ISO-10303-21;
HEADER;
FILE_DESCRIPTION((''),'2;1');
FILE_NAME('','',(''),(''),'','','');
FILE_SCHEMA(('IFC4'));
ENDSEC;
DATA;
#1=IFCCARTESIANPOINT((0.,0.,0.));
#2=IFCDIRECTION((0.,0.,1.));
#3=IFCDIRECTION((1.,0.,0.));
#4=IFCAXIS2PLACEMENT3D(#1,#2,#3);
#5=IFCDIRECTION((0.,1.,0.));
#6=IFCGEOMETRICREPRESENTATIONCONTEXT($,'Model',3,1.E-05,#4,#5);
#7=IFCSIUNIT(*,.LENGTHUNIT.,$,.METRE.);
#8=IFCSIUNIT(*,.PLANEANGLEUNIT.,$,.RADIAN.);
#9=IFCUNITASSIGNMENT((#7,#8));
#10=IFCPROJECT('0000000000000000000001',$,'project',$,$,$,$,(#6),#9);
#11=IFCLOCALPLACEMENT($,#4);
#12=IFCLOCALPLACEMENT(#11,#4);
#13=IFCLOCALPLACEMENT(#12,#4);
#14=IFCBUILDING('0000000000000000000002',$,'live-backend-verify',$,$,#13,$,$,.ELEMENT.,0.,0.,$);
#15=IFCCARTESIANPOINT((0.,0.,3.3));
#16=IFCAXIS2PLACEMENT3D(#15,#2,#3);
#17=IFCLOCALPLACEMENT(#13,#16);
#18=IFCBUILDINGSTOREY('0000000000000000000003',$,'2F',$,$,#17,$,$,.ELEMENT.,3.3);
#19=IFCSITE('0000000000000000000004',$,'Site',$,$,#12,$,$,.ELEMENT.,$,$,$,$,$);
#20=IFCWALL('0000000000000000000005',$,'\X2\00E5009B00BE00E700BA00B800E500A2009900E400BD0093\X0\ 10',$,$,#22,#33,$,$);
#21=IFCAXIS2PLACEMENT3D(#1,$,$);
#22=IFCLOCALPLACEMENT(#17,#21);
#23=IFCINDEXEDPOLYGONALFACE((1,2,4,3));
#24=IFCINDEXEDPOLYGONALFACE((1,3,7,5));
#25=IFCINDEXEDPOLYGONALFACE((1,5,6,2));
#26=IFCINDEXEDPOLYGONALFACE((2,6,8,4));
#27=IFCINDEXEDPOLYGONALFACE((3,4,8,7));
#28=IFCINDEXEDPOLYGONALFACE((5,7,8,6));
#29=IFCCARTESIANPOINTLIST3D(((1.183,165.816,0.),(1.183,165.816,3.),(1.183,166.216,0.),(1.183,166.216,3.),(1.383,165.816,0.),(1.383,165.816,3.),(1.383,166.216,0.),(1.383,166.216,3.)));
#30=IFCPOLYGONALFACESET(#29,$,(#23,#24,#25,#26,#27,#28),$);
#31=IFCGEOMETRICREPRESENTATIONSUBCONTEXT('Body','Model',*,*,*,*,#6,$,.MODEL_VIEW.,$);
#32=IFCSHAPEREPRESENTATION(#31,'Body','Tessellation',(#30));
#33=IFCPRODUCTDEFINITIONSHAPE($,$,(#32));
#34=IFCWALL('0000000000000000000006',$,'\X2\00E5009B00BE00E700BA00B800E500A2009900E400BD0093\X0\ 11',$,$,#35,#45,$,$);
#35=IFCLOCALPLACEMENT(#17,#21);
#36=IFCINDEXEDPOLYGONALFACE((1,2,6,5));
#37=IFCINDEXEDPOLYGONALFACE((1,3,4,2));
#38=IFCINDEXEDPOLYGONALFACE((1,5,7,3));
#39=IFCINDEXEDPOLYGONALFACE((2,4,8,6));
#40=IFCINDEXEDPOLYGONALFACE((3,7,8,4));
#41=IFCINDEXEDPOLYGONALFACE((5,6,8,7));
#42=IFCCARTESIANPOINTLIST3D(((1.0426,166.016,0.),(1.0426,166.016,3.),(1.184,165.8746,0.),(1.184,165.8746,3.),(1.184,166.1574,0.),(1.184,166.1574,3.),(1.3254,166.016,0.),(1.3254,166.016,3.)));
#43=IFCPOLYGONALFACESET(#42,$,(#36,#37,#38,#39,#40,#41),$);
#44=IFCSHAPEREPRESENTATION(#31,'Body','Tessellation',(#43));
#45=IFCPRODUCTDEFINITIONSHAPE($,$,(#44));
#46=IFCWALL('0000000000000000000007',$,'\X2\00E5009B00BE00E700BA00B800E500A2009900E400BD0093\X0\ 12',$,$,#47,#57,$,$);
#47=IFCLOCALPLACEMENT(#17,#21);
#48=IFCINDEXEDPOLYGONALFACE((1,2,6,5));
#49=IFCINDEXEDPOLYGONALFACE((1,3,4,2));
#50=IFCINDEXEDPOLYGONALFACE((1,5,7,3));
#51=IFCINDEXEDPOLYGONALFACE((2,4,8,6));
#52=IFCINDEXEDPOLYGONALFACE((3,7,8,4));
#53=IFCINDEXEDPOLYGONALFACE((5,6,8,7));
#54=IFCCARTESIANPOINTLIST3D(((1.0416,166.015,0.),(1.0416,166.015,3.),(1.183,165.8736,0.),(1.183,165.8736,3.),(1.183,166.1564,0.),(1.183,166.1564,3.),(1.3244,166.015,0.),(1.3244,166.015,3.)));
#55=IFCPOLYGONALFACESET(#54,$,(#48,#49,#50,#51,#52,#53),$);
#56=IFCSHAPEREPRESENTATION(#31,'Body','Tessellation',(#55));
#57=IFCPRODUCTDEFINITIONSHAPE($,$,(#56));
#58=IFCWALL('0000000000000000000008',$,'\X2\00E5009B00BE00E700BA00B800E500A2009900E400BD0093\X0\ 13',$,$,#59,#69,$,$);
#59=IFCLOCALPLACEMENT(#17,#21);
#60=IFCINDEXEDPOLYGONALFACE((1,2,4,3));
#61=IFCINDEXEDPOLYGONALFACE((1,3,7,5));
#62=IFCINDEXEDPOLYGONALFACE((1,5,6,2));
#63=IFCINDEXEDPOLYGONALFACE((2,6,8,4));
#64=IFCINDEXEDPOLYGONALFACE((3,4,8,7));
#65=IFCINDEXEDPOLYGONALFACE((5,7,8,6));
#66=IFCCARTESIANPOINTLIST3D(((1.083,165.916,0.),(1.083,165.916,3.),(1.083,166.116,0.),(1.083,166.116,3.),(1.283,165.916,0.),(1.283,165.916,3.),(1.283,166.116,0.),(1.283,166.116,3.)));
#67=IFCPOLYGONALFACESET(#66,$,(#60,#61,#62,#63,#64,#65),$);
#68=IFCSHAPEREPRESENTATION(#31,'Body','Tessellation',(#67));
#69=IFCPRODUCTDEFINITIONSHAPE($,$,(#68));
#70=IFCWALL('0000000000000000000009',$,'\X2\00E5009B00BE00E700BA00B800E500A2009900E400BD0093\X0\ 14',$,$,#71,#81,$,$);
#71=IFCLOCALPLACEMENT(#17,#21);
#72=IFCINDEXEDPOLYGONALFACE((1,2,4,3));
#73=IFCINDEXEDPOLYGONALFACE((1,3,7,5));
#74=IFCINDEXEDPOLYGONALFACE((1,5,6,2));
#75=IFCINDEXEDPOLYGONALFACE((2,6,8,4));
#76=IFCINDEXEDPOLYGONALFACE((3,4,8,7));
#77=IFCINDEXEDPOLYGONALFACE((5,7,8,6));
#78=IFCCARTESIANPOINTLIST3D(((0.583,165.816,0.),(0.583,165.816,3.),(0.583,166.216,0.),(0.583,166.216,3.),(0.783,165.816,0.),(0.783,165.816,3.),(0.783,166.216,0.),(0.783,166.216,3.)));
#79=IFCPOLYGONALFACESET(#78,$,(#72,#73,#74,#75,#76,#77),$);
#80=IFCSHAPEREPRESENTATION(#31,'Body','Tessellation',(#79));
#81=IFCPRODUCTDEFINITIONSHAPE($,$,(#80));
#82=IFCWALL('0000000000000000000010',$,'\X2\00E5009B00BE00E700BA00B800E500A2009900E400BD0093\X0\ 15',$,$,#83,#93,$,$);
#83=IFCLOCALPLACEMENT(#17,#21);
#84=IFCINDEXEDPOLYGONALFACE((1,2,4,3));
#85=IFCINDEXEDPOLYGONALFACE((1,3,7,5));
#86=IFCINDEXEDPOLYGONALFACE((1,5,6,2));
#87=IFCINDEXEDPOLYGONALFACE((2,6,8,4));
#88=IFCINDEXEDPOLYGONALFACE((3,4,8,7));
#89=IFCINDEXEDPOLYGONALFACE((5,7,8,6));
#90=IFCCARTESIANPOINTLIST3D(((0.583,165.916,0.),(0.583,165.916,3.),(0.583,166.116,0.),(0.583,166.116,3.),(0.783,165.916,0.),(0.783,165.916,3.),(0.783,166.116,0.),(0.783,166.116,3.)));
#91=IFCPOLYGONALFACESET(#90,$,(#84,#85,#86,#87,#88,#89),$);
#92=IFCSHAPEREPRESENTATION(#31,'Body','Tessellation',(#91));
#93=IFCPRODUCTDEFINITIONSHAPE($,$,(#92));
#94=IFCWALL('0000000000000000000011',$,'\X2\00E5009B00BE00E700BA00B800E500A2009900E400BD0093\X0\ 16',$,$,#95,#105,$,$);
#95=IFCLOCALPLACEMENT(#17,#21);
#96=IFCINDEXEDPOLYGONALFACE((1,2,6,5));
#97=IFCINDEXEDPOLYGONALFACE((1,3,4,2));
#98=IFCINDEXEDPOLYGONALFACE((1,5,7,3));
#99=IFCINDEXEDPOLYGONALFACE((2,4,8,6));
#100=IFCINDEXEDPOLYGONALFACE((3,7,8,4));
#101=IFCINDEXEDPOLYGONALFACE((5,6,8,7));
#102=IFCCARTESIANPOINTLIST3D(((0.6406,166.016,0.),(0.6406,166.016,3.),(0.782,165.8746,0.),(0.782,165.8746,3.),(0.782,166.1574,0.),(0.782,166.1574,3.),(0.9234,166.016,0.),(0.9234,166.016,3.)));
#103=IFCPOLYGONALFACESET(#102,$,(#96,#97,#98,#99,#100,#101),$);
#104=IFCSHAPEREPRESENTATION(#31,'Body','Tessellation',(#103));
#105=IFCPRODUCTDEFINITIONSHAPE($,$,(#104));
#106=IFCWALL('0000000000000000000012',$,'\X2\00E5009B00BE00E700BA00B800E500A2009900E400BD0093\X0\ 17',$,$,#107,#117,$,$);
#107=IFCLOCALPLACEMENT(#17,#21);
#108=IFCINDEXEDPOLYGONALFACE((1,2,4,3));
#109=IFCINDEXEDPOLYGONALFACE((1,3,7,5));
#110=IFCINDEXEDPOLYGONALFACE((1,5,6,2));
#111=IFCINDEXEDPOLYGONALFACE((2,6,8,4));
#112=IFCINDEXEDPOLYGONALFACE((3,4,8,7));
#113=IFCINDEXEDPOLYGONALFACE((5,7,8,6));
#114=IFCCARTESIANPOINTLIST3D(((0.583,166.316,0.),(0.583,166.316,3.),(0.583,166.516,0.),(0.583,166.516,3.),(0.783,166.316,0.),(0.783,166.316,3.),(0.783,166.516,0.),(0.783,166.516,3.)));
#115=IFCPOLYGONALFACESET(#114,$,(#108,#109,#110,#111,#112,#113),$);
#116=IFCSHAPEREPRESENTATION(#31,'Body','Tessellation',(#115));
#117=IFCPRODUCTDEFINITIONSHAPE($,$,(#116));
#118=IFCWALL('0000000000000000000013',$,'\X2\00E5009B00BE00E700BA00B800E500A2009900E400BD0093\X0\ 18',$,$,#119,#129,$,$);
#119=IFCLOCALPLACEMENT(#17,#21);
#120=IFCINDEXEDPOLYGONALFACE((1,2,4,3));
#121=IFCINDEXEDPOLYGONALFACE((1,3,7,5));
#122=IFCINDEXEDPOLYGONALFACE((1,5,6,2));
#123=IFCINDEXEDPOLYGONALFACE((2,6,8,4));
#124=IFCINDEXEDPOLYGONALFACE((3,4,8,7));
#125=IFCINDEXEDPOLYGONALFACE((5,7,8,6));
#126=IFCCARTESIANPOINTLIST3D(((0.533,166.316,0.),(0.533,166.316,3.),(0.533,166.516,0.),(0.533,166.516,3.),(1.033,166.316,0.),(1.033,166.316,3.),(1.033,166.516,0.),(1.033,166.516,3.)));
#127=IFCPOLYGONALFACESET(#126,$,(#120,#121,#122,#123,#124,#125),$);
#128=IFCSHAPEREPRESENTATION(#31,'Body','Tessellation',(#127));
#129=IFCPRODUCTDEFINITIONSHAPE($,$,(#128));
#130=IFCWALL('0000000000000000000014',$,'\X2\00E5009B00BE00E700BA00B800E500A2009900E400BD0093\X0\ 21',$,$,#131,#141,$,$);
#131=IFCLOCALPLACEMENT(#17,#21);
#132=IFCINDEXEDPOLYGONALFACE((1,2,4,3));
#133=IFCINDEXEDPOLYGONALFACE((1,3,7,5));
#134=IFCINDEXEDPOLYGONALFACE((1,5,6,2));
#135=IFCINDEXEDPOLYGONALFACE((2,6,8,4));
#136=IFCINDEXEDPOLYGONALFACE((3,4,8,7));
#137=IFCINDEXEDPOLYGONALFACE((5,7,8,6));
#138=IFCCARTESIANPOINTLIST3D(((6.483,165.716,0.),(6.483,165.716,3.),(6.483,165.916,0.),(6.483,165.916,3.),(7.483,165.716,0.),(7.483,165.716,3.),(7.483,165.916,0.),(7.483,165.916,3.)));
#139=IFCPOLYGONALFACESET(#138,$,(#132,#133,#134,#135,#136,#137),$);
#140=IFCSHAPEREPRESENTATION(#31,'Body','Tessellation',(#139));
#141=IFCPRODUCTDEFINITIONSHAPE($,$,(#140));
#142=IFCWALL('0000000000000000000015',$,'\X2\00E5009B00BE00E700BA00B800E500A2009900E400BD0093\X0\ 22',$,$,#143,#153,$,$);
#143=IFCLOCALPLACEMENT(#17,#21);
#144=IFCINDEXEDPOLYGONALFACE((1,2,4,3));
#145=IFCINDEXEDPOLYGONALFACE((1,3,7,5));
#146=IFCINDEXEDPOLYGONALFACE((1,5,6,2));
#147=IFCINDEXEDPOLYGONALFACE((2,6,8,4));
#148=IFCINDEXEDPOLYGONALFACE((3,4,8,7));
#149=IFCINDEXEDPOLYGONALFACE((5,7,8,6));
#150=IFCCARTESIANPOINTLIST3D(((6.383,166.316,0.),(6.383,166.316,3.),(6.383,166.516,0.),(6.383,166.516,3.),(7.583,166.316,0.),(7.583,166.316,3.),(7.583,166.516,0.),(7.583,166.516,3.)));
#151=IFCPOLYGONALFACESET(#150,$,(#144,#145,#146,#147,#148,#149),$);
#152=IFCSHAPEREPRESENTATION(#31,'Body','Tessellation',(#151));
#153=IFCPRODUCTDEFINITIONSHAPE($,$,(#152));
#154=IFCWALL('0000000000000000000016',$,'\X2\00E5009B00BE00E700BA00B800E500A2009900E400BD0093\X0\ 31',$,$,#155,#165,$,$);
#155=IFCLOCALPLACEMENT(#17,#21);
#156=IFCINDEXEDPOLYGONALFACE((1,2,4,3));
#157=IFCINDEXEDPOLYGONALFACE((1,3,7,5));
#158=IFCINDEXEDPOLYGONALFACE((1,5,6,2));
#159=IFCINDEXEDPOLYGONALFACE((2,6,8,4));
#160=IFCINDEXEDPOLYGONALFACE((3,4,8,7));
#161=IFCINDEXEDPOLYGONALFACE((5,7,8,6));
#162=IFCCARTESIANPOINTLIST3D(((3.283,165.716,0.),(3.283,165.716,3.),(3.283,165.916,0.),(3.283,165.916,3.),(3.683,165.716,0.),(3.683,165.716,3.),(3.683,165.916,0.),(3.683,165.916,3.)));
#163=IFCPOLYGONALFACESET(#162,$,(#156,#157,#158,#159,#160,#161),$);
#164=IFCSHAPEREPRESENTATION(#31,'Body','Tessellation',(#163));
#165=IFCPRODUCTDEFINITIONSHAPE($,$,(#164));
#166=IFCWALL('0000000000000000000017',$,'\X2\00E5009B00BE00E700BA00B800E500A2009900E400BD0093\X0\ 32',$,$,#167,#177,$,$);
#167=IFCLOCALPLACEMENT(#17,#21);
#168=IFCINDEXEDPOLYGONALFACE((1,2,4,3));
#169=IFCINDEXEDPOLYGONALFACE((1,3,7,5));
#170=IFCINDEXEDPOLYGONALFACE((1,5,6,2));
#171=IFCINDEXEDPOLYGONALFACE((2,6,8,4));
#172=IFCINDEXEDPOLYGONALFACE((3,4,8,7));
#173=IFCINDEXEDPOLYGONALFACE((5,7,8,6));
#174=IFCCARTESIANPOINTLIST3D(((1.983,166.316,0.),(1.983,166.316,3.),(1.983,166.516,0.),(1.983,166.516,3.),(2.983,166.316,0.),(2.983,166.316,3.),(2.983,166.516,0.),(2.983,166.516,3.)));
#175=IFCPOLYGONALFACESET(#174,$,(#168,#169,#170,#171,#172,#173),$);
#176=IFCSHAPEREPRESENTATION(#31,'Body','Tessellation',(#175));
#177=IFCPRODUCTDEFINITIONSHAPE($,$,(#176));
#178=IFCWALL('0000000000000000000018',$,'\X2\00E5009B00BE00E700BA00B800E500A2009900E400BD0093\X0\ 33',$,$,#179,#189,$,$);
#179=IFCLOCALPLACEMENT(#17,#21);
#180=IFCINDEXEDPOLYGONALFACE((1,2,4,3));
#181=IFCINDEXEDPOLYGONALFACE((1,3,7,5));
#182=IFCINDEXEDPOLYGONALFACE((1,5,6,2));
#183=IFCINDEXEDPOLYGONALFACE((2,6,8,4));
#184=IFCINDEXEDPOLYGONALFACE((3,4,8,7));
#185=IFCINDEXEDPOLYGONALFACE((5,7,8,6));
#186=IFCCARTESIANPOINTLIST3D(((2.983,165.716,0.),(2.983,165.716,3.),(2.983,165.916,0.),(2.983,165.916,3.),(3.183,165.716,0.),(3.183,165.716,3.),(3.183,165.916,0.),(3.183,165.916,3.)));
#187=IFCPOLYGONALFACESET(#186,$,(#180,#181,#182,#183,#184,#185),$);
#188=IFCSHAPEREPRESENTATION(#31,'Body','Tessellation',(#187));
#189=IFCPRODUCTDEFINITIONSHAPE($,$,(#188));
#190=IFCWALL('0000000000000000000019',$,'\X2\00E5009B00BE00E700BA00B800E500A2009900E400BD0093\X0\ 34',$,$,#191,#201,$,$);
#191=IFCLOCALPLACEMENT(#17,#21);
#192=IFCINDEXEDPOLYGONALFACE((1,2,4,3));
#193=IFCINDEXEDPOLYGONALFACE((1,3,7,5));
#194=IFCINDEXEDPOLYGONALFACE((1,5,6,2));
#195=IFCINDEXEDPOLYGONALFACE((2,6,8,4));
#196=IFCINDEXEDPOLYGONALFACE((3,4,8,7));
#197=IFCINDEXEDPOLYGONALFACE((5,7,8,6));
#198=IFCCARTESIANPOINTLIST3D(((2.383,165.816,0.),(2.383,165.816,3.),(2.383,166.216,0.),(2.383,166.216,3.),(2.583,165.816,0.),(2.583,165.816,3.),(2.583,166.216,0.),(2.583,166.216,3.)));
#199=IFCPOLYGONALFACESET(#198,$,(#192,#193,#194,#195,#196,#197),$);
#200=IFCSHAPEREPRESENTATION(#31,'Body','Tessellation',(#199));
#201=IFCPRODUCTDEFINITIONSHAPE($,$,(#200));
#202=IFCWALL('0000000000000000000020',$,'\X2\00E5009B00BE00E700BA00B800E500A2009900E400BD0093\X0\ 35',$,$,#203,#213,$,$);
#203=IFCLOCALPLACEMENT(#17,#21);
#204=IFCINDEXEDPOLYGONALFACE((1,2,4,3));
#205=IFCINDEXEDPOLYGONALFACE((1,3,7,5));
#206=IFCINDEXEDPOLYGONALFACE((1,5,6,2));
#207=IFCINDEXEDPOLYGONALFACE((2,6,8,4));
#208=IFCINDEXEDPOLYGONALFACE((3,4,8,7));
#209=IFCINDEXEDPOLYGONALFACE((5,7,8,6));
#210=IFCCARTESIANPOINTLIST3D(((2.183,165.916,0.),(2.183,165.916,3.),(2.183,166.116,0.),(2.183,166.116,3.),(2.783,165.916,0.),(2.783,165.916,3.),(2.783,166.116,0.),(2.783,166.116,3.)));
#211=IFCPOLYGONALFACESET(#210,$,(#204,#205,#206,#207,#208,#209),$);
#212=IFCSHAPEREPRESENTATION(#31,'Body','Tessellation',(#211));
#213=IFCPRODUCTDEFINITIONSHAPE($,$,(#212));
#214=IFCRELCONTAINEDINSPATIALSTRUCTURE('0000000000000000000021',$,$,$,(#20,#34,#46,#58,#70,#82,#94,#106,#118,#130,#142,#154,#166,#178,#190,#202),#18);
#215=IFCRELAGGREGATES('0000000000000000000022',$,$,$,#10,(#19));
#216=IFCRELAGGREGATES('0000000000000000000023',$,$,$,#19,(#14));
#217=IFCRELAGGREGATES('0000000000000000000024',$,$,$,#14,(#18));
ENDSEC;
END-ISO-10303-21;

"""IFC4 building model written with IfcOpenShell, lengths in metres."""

from ifc_helpers import new_model, si_unit, direction, frame, frame_2d, origin_with_axes, place, context, subcontext, project, spatial, rectangle, extrude, element, save


model = new_model("IFC4")

# Units and contexts
model_context = context("Model", 3, precision=1e-05, world=origin_with_axes(), true_north=direction((0.0, 1.0, 0.0)))
body_context = subcontext(model_context, "Body", "Model", "MODEL_VIEW")
ifc_project = project(units=[si_unit("LENGTHUNIT", "METRE"), si_unit("PLANEANGLEUNIT", "RADIAN")], contexts=[model_context])

# Site, building, storey
placement = place(None, origin_with_axes())
site_placement = place(placement, origin_with_axes())
site = spatial("IfcSite", under=ifc_project, at=site_placement, Name="Site", CompositionType="ELEMENT")
building_placement = place(site_placement, origin_with_axes())
building = spatial("IfcBuilding", under=site, at=building_placement, Name="live-backend-verify", CompositionType="ELEMENT", ElevationOfRefHeight=0.0, ElevationOfTerrain=0.0)
storey_placement = place(building_placement, frame((0.0, 0.0, 3.3), z_axis=(0.0, 0.0, 1.0), x_axis=(1.0, 0.0, 0.0)))
storey = spatial("IfcBuildingStorey", under=building, at=storey_placement, Name="2F", CompositionType="ELEMENT", Elevation=3.3)

# Walls
wall_1_placement = place(storey_placement, frame((1.283, 166.016, 0.0), z_axis=(0.0, 0.0, 1.0), x_axis=(0.0, 1.0, 0.0)))
element("IfcWall", 1, at=wall_1_placement, inside=storey, Name="å\u009b¾çº¸å¢\u0099ä½\u0093 10", context=body_context, shape_type="SweptSolid", body=[
    extrude(rectangle(XDim=0.4, YDim=0.2, at=frame_2d((0.0, 0.0), x_axis=(1.0, 0.0, 0.0))), frame((0.0, 0.0, 0.0), z_axis=(0.0, 0.0, 1.0)), (0.0, 0.0, 1.0), 3.0),
])
for number, where, z_axis, x_axis, name in (
    (2, (1.184, 166.016, 0.0), (0.0, 0.0, 1.0), (-0.707107, -0.707107, 0.0), "å\u009b¾çº¸å¢\u0099ä½\u0093 11"),
    (3, (1.183, 166.015, 0.0), (0.0, 0.0, 1.0), (0.707107, 0.707107, 0.0), "å\u009b¾çº¸å¢\u0099ä½\u0093 12"),
    (4, (1.183, 166.016, 0.0), (0.0, 0.0, 1.0), (1.0, 0.0, 0.0), "å\u009b¾çº¸å¢\u0099ä½\u0093 13"),
):
    element("IfcWall", number, at=place(storey_placement, frame(where, z_axis=z_axis, x_axis=x_axis)), inside=storey, Name=name, context=body_context, shape_type="SweptSolid", body=[
        extrude(rectangle(XDim=0.2, YDim=0.2, at=frame_2d((0.0, 0.0), x_axis=(1.0, 0.0, 0.0))), frame((0.0, 0.0, 0.0), z_axis=(0.0, 0.0, 1.0)), (0.0, 0.0, 1.0), 3.0),
    ])
wall_2_placement = place(storey_placement, frame((0.683, 166.016, 0.0), z_axis=(0.0, 0.0, 1.0), x_axis=(0.0, 1.0, 0.0)))
element("IfcWall", 5, at=wall_2_placement, inside=storey, Name="å\u009b¾çº¸å¢\u0099ä½\u0093 14", context=body_context, shape_type="SweptSolid", body=[
    extrude(rectangle(XDim=0.4, YDim=0.2, at=frame_2d((0.0, 0.0), x_axis=(1.0, 0.0, 0.0))), frame((0.0, 0.0, 0.0), z_axis=(0.0, 0.0, 1.0)), (0.0, 0.0, 1.0), 3.0),
])
for number, where, z_axis, x_axis, name in (
    (6, (0.683, 166.016, 0.0), (0.0, 0.0, 1.0), (1.0, 0.0, 0.0), "å\u009b¾çº¸å¢\u0099ä½\u0093 15"),
    (7, (0.782, 166.016, 0.0), (0.0, 0.0, 1.0), (0.707107, -0.707107, 0.0), "å\u009b¾çº¸å¢\u0099ä½\u0093 16"),
    (8, (0.683, 166.416, 0.0), (0.0, 0.0, 1.0), (1.0, 0.0, 0.0), "å\u009b¾çº¸å¢\u0099ä½\u0093 17"),
):
    element("IfcWall", number, at=place(storey_placement, frame(where, z_axis=z_axis, x_axis=x_axis)), inside=storey, Name=name, context=body_context, shape_type="SweptSolid", body=[
        extrude(rectangle(XDim=0.2, YDim=0.2, at=frame_2d((0.0, 0.0), x_axis=(1.0, 0.0, 0.0))), frame((0.0, 0.0, 0.0), z_axis=(0.0, 0.0, 1.0)), (0.0, 0.0, 1.0), 3.0),
    ])
wall_3_placement = place(storey_placement, frame((0.783, 166.416, 0.0), z_axis=(0.0, 0.0, 1.0), x_axis=(1.0, 0.0, 0.0)))
element("IfcWall", 9, at=wall_3_placement, inside=storey, Name="å\u009b¾çº¸å¢\u0099ä½\u0093 18", context=body_context, shape_type="SweptSolid", body=[
    extrude(rectangle(XDim=0.5, YDim=0.2, at=frame_2d((0.0, 0.0), x_axis=(1.0, 0.0, 0.0))), frame((0.0, 0.0, 0.0), z_axis=(0.0, 0.0, 1.0)), (0.0, 0.0, 1.0), 3.0),
])
wall_4_placement = place(storey_placement, frame((6.983, 165.816, 0.0), z_axis=(0.0, 0.0, 1.0), x_axis=(1.0, 0.0, 0.0)))
element("IfcWall", 10, at=wall_4_placement, inside=storey, Name="å\u009b¾çº¸å¢\u0099ä½\u0093 21", context=body_context, shape_type="SweptSolid", body=[
    extrude(rectangle(XDim=1.0, YDim=0.2, at=frame_2d((0.0, 0.0), x_axis=(1.0, 0.0, 0.0))), frame((0.0, 0.0, 0.0), z_axis=(0.0, 0.0, 1.0)), (0.0, 0.0, 1.0), 3.0),
])
wall_5_placement = place(storey_placement, frame((6.983, 166.416, 0.0), z_axis=(0.0, 0.0, 1.0), x_axis=(1.0, 0.0, 0.0)))
element("IfcWall", 11, at=wall_5_placement, inside=storey, Name="å\u009b¾çº¸å¢\u0099ä½\u0093 22", context=body_context, shape_type="SweptSolid", body=[
    extrude(rectangle(XDim=1.2, YDim=0.2, at=frame_2d((0.0, 0.0), x_axis=(1.0, 0.0, 0.0))), frame((0.0, 0.0, 0.0), z_axis=(0.0, 0.0, 1.0)), (0.0, 0.0, 1.0), 3.0),
])
wall_6_placement = place(storey_placement, frame((3.483, 165.816, 0.0), z_axis=(0.0, 0.0, 1.0), x_axis=(-1.0, 0.0, 0.0)))
element("IfcWall", 12, at=wall_6_placement, inside=storey, Name="å\u009b¾çº¸å¢\u0099ä½\u0093 31", context=body_context, shape_type="SweptSolid", body=[
    extrude(rectangle(XDim=0.4, YDim=0.2, at=frame_2d((0.0, 0.0), x_axis=(1.0, 0.0, 0.0))), frame((0.0, 0.0, 0.0), z_axis=(0.0, 0.0, 1.0)), (0.0, 0.0, 1.0), 3.0),
])
wall_7_placement = place(storey_placement, frame((2.483, 166.416, 0.0), z_axis=(0.0, 0.0, 1.0), x_axis=(1.0, 0.0, 0.0)))
element("IfcWall", 13, at=wall_7_placement, inside=storey, Name="å\u009b¾çº¸å¢\u0099ä½\u0093 32", context=body_context, shape_type="SweptSolid", body=[
    extrude(rectangle(XDim=1.0, YDim=0.2, at=frame_2d((0.0, 0.0), x_axis=(1.0, 0.0, 0.0))), frame((0.0, 0.0, 0.0), z_axis=(0.0, 0.0, 1.0)), (0.0, 0.0, 1.0), 3.0),
])
wall_8_placement = place(storey_placement, frame((3.083, 165.816, 0.0), z_axis=(0.0, 0.0, 1.0), x_axis=(0.0, 1.0, 0.0)))
element("IfcWall", 14, at=wall_8_placement, inside=storey, Name="å\u009b¾çº¸å¢\u0099ä½\u0093 33", context=body_context, shape_type="SweptSolid", body=[
    extrude(rectangle(XDim=0.2, YDim=0.2, at=frame_2d((0.0, 0.0), x_axis=(1.0, 0.0, 0.0))), frame((0.0, 0.0, 0.0), z_axis=(0.0, 0.0, 1.0)), (0.0, 0.0, 1.0), 3.0),
])
wall_9_placement = place(storey_placement, frame((2.483, 166.016, 0.0), z_axis=(0.0, 0.0, 1.0), x_axis=(0.0, 1.0, 0.0)))
element("IfcWall", 15, at=wall_9_placement, inside=storey, Name="å\u009b¾çº¸å¢\u0099ä½\u0093 34", context=body_context, shape_type="SweptSolid", body=[
    extrude(rectangle(XDim=0.4, YDim=0.2, at=frame_2d((0.0, 0.0), x_axis=(1.0, 0.0, 0.0))), frame((0.0, 0.0, 0.0), z_axis=(0.0, 0.0, 1.0)), (0.0, 0.0, 1.0), 3.0),
])
for number, where, z_axis, x_axis, name in (
    (16, (2.483, 166.016, 0.0), (0.0, 0.0, 1.0), (1.0, 0.0, 0.0), "å\u009b¾çº¸å¢\u0099ä½\u0093 35"),
):
    element("IfcWall", number, at=place(storey_placement, frame(where, z_axis=z_axis, x_axis=x_axis)), inside=storey, Name=name, context=body_context, shape_type="SweptSolid", body=[
        extrude(rectangle(XDim=0.6, YDim=0.2, at=frame_2d((0.0, 0.0), x_axis=(1.0, 0.0, 0.0))), frame((0.0, 0.0, 0.0), z_axis=(0.0, 0.0, 1.0)), (0.0, 0.0, 1.0), 3.0),
    ])

save(model, "model.ifc")
